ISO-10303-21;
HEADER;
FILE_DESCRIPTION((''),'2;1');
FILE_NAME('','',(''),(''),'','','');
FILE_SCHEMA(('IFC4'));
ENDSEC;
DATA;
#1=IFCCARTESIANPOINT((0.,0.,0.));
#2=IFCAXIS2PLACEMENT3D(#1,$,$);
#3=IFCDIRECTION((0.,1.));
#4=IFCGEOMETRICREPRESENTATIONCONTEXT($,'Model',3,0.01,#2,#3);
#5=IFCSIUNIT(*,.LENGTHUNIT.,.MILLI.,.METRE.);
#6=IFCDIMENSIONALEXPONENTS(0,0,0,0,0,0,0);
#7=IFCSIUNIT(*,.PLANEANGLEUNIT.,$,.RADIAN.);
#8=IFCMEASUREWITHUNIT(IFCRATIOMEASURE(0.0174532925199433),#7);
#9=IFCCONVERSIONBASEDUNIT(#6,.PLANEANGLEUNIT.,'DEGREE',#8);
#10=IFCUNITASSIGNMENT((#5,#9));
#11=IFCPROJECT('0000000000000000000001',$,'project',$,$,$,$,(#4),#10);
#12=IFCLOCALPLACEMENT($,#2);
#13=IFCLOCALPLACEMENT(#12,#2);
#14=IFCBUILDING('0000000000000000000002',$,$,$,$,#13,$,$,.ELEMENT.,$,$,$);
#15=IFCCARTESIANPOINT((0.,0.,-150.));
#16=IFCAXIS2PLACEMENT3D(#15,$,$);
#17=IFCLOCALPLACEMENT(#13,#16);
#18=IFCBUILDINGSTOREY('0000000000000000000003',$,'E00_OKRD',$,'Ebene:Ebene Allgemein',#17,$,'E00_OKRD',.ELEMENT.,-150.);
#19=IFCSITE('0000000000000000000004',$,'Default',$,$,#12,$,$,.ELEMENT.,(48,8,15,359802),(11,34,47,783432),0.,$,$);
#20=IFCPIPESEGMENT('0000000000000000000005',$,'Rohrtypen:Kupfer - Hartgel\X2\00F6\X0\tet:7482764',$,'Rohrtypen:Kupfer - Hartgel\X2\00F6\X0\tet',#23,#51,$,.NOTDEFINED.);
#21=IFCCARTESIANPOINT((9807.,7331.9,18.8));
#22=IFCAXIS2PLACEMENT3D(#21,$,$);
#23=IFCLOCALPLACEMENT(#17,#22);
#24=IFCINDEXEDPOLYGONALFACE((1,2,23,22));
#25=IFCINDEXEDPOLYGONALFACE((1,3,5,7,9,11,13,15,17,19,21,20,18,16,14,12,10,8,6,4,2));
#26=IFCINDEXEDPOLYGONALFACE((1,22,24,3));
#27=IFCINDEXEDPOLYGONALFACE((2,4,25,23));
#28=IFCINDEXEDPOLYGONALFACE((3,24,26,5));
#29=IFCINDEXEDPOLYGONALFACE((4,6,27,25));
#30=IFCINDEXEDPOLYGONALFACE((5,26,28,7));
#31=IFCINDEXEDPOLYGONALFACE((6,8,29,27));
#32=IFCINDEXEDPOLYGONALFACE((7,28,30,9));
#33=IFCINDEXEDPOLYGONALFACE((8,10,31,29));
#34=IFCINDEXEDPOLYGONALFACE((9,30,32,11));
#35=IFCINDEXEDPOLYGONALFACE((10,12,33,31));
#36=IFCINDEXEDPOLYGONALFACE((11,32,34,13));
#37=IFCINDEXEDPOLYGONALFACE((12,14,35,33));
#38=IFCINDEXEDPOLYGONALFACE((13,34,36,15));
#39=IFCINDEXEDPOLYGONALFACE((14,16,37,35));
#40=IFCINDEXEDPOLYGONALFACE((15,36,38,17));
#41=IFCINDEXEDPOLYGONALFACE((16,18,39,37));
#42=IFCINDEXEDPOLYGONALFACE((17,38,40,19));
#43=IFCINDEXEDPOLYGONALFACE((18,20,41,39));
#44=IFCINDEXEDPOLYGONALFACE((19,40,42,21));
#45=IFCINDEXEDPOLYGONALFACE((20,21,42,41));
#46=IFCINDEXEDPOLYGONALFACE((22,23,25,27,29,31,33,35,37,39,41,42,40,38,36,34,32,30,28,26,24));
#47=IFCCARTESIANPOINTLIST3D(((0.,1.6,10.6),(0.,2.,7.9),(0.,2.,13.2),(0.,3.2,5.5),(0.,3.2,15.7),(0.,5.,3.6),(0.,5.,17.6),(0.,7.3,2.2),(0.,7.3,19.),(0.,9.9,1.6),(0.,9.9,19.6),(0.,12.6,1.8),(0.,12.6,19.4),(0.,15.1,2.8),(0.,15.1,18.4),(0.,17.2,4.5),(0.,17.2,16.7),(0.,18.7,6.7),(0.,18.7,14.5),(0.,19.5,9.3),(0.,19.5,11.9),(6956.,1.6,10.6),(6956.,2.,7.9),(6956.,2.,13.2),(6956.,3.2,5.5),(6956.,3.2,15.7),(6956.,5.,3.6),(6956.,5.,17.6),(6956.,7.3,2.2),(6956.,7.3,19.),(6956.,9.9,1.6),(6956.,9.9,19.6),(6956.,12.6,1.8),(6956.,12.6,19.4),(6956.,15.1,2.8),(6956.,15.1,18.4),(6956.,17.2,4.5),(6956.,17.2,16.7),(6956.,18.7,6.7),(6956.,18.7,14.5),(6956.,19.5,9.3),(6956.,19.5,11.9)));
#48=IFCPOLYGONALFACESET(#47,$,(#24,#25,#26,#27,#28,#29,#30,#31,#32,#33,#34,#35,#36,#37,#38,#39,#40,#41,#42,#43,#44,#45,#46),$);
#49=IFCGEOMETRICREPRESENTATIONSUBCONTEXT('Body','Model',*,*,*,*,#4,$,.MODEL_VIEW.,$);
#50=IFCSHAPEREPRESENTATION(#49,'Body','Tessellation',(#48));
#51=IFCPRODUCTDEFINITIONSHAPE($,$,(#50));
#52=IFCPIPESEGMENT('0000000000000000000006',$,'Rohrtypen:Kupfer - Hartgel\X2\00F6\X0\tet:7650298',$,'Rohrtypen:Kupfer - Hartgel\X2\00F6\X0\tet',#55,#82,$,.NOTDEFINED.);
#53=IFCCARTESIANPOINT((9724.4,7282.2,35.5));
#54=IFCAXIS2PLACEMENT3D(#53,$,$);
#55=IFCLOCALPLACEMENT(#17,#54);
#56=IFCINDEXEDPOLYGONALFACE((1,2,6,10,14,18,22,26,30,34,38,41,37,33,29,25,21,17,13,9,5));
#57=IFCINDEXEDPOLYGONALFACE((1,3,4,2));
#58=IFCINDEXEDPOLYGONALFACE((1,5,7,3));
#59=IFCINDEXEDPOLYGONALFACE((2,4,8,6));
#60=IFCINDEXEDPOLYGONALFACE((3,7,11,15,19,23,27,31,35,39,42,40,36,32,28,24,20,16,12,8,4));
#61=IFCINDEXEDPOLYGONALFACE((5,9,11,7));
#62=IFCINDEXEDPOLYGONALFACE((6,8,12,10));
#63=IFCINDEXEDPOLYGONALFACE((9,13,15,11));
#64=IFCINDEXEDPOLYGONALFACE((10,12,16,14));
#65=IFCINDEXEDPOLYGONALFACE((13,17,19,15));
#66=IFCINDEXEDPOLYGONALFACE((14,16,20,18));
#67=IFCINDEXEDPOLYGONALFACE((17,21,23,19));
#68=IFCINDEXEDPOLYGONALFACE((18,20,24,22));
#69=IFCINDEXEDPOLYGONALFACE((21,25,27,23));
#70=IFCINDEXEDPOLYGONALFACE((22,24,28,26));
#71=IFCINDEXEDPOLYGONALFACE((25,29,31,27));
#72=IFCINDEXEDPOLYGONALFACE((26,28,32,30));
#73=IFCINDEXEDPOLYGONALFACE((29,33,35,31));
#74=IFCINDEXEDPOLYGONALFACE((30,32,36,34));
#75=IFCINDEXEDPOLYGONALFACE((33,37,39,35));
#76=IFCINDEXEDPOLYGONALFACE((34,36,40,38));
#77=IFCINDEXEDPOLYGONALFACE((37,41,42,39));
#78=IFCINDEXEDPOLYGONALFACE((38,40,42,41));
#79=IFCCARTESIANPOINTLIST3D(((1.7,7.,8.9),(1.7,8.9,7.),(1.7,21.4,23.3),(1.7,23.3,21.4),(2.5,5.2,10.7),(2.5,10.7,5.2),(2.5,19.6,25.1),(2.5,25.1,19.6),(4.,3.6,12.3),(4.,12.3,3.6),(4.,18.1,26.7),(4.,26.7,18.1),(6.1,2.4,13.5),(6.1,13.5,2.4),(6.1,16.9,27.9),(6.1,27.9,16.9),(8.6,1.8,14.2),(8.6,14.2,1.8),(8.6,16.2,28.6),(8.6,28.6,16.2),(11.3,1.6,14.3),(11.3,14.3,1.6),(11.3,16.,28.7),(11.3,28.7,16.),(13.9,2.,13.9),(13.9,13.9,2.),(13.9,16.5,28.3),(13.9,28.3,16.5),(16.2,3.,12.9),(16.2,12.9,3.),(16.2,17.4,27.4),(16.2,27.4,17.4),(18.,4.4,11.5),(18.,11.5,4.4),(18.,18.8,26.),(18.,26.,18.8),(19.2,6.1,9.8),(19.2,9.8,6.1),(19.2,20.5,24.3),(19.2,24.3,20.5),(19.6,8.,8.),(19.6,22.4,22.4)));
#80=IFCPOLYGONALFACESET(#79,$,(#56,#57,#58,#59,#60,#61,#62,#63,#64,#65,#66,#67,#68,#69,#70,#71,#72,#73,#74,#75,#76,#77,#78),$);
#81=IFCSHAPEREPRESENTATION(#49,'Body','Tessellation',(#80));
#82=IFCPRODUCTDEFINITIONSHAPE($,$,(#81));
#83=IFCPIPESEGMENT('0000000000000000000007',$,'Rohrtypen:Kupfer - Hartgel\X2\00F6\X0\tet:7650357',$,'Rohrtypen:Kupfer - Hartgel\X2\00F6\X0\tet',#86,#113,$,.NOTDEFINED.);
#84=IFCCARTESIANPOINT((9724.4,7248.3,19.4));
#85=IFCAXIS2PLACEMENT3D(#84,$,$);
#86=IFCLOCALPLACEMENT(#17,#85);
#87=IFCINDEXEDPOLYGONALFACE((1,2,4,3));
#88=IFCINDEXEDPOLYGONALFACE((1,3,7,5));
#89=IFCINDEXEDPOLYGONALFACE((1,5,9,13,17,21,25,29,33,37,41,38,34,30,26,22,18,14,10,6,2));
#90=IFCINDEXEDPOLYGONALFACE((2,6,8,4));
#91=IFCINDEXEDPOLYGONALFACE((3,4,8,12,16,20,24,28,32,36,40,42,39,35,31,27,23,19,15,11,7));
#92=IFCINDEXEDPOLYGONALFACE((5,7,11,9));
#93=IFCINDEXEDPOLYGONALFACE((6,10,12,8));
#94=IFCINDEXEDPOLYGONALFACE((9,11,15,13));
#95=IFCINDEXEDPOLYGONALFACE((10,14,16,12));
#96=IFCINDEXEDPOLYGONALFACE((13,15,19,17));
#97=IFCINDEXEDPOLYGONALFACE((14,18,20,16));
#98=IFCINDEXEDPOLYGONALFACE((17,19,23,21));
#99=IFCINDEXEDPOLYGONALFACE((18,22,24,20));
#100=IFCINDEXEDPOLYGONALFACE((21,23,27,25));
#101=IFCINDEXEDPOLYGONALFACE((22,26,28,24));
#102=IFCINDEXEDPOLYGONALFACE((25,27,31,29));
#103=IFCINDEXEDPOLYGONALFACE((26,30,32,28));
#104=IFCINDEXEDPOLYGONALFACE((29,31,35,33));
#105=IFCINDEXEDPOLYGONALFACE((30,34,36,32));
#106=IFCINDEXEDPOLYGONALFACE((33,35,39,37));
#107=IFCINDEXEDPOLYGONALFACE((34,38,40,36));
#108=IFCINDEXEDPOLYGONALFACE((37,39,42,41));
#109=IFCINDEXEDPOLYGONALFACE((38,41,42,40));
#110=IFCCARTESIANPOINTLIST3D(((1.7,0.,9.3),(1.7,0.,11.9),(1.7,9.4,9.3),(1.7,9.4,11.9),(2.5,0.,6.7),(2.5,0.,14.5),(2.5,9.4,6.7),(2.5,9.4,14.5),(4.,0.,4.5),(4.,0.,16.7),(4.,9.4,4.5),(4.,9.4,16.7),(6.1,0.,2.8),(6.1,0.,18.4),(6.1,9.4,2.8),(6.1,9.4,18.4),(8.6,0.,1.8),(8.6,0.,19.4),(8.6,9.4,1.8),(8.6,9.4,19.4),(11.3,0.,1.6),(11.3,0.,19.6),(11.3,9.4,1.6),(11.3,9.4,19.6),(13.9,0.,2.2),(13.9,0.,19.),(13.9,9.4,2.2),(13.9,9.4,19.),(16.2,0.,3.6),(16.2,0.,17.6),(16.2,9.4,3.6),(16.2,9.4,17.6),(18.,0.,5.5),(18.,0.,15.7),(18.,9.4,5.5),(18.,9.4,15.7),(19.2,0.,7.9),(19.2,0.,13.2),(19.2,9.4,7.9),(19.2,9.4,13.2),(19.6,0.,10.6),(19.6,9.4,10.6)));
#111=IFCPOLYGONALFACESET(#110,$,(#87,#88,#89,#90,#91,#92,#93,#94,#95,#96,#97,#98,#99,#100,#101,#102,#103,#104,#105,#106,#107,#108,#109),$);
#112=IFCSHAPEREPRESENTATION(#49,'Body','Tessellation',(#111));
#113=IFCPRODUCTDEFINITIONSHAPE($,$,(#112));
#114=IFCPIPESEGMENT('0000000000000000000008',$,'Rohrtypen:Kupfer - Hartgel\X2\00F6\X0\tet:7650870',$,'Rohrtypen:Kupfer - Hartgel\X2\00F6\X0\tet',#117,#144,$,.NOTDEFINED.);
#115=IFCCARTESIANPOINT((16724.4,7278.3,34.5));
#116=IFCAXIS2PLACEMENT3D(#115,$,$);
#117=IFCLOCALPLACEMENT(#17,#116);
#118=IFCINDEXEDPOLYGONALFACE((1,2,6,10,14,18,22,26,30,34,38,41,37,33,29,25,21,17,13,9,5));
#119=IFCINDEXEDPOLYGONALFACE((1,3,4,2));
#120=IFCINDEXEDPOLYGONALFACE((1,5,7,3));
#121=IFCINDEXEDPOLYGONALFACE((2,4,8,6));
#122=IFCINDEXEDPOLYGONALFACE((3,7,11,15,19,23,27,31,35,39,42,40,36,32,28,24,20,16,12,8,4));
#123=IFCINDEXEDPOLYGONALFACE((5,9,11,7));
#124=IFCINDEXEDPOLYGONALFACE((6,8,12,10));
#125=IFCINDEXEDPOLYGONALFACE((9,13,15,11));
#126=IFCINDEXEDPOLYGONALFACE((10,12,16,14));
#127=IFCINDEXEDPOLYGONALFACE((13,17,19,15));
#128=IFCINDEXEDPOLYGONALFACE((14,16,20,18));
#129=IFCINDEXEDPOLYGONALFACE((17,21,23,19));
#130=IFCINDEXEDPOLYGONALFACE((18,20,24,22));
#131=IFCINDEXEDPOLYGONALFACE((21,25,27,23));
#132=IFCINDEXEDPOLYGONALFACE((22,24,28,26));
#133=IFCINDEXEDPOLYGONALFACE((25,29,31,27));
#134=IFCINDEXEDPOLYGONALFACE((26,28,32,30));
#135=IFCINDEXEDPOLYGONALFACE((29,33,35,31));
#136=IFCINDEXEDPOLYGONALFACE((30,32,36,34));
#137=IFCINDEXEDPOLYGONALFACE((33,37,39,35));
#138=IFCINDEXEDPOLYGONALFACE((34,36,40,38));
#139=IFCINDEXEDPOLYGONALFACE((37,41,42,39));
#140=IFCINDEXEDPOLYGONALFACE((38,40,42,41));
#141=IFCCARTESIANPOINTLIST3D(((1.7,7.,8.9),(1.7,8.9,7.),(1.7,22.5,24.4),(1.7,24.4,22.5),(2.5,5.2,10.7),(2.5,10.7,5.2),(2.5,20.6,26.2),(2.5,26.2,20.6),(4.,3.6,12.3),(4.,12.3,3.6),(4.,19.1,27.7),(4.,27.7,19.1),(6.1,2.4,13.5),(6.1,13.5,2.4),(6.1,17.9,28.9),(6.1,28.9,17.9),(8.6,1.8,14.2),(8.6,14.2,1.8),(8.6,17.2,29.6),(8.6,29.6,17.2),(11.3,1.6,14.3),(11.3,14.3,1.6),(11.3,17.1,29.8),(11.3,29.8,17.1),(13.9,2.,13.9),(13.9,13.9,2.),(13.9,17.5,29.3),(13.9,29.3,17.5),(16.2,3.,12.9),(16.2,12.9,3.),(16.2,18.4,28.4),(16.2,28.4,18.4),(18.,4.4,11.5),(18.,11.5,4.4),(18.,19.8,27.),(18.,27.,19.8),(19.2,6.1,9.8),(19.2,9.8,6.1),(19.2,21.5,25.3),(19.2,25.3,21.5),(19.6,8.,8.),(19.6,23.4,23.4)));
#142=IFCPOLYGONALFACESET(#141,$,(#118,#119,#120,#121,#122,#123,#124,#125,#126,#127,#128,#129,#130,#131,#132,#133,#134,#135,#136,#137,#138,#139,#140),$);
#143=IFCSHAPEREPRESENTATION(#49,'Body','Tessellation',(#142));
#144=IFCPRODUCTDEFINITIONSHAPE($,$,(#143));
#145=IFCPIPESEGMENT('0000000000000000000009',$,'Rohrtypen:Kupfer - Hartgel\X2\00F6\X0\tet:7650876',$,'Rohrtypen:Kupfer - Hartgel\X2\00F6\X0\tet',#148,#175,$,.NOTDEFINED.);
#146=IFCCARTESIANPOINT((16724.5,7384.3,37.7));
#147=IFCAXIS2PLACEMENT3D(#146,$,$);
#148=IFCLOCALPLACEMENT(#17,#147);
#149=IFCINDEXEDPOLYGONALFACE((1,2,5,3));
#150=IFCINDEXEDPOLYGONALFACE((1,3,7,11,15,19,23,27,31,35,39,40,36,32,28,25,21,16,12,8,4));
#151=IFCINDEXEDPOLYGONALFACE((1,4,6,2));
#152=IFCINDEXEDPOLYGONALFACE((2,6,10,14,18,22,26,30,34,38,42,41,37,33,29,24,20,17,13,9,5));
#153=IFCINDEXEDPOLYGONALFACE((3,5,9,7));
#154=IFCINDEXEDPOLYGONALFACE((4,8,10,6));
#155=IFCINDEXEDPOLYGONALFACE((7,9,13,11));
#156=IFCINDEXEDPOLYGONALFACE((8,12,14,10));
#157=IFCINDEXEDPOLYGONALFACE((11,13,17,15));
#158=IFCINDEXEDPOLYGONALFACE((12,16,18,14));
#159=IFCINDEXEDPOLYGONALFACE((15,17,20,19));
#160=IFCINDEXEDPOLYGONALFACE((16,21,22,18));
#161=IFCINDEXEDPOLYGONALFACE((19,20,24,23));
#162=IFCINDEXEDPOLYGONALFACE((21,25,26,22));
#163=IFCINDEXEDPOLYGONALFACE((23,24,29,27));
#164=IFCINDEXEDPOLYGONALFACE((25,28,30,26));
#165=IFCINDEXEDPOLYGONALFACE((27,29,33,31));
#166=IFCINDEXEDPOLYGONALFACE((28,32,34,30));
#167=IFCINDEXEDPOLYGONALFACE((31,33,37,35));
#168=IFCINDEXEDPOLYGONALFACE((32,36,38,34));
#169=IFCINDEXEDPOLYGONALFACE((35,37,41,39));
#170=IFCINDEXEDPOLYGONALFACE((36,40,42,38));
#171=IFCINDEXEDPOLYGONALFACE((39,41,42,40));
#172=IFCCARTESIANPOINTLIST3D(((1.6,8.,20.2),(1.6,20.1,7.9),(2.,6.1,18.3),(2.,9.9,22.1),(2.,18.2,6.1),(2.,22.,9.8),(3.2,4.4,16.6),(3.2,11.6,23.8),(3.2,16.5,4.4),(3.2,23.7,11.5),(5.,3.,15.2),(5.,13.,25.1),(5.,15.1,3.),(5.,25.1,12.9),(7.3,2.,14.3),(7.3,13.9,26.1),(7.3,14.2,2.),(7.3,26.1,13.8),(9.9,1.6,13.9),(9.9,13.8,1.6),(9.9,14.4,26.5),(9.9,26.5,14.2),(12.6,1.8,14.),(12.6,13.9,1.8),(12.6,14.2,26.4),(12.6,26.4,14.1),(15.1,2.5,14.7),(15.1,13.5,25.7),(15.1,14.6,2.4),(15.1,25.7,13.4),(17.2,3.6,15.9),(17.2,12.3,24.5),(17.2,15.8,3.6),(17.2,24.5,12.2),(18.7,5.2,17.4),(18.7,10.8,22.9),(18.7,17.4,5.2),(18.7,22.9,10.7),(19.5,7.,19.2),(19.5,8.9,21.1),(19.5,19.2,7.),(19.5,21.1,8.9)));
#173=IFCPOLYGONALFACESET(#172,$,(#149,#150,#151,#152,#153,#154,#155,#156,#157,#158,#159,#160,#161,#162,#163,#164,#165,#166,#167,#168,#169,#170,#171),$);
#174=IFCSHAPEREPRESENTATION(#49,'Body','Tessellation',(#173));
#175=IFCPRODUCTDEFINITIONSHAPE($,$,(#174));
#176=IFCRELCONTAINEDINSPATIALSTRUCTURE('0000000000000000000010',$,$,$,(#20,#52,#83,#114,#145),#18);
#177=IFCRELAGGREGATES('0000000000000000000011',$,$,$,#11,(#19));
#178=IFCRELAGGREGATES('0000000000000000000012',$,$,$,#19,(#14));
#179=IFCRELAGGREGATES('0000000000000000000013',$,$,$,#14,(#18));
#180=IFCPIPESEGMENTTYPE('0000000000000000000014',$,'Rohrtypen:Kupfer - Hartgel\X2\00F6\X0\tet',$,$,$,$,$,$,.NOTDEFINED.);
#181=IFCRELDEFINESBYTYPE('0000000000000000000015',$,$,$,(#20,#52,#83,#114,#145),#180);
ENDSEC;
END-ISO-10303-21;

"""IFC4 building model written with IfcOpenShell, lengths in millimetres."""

from ifc_helpers import new_model, entity, si_unit, converted_unit, direction, frame, frame_2d, origin, place, context, subcontext, project, spatial, circle, extrude, type_object, element, save


model = new_model("IFC4")

# Units and contexts
model_context = context("Model", 3, precision=0.01, world=origin(), true_north=direction((0.0, 1.0)))
body_context = subcontext(model_context, "Body", "Model", "MODEL_VIEW")
ifc_project = project(units=[si_unit("LENGTHUNIT", "METRE", prefix="MILLI"), converted_unit("PLANEANGLEUNIT", "DEGREE", entity("IfcRatioMeasure", 0.0174532925199433), si_unit("PLANEANGLEUNIT", "RADIAN"), dimensions=[0, 0, 0, 0, 0, 0, 0])], contexts=[model_context])

# Site, building, storey
site_placement = place(None, origin())
site = spatial("IfcSite", under=ifc_project, at=site_placement, Name="Default", CompositionType="ELEMENT", RefLatitude=(48, 8, 15, 359802), RefLongitude=(11, 34, 47, 783432), RefElevation=0.0)
building_placement = place(site_placement, origin())
building = spatial("IfcBuilding", under=site, at=building_placement, CompositionType="ELEMENT")
storey_placement = place(building_placement, frame((0.0, 0.0, -150.0)))
storey = spatial("IfcBuildingStorey", under=building, at=storey_placement, Name="E00_OKRD", ObjectType="Ebene:Ebene Allgemein", LongName="E00_OKRD", CompositionType="ELEMENT", Elevation=-150.0)

# Pipe segments
pipe_segment_type = type_object("IfcPipeSegmentType", Name="Rohrtypen:Kupfer - Hartgelötet", PredefinedType="NOTDEFINED")
pipe_segment_1_placement = place(storey_placement, frame((9807.0, 7331.9, 18.8)))
element("IfcPipeSegment", 1, at=pipe_segment_1_placement, inside=storey, type_object=pipe_segment_type, Name="Rohrtypen:Kupfer - Hartgelötet:7482764", ObjectType="Rohrtypen:Kupfer - Hartgelötet", PredefinedType="NOTDEFINED", context=body_context, shape_type="SweptSolid", body=[
    extrude(circle(Radius=9.0, at=frame_2d((0.0, 0.0), x_axis=(1.0, 0.0))), frame((0.0, 10.6, 10.6), z_axis=(1.0, 0.0, 0.0), x_axis=(0.0, -1.0, 0.0)), (0.0, 0.0, 1.0), 6956.0),
])
pipe_segment_2_placement = place(storey_placement, frame((9724.4, 7282.2, 35.5)))
element("IfcPipeSegment", 2, at=pipe_segment_2_placement, inside=storey, type_object=pipe_segment_type, Name="Rohrtypen:Kupfer - Hartgelötet:7650298", ObjectType="Rohrtypen:Kupfer - Hartgelötet", PredefinedType="NOTDEFINED", context=body_context, shape_type="SweptSolid", body=[
    extrude(circle(Radius=9.0, at=frame_2d((0.0, 0.0), x_axis=(1.0, 0.0))), frame((10.6, 8.0, 8.0), z_axis=(0.0, 0.707107, 0.707107), x_axis=(1.0, 0.0, 0.0)), (0.0, 0.0, 1.0), 20.4),
])
pipe_segment_3_placement = place(storey_placement, frame((9724.4, 7248.3, 19.4)))
element("IfcPipeSegment", 3, at=pipe_segment_3_placement, inside=storey, type_object=pipe_segment_type, Name="Rohrtypen:Kupfer - Hartgelötet:7650357", ObjectType="Rohrtypen:Kupfer - Hartgelötet", PredefinedType="NOTDEFINED", context=body_context, shape_type="SweptSolid", body=[
    extrude(circle(Radius=9.0, at=frame_2d((0.0, 0.0), x_axis=(1.0, 0.0))), frame((10.6, 0.0, 10.6), z_axis=(0.0, 1.0, 0.0), x_axis=(1.0, 0.0, 0.0)), (0.0, 0.0, 1.0), 9.4),
])
pipe_segment_4_placement = place(storey_placement, frame((16724.4, 7278.3, 34.5)))
element("IfcPipeSegment", 4, at=pipe_segment_4_placement, inside=storey, type_object=pipe_segment_type, Name="Rohrtypen:Kupfer - Hartgelötet:7650870", ObjectType="Rohrtypen:Kupfer - Hartgelötet", PredefinedType="NOTDEFINED", context=body_context, shape_type="SweptSolid", body=[
    extrude(circle(Radius=9.0, at=frame_2d((0.0, 0.0), x_axis=(1.0, 0.0))), frame((10.6, 8.0, 8.0), z_axis=(0.0, 0.707107, 0.707107), x_axis=(1.0, 0.0, 0.0)), (0.0, 0.0, 1.0), 21.8),
])
pipe_segment_5_placement = place(storey_placement, frame((16724.5, 7384.3, 37.7)))
element("IfcPipeSegment", 5, at=pipe_segment_5_placement, inside=storey, type_object=pipe_segment_type, Name="Rohrtypen:Kupfer - Hartgelötet:7650876", ObjectType="Rohrtypen:Kupfer - Hartgelötet", PredefinedType="NOTDEFINED", context=body_context, shape_type="SweptSolid", body=[
    extrude(circle(Radius=9.0, at=frame_2d((0.0, 0.0), x_axis=(1.0, 0.0))), frame((10.6, 8.0, 20.2), z_axis=(0.0, 0.70394, -0.71026), x_axis=(-1.0, 0.0, 0.0)), (0.0, 0.0, 1.0), 17.3),
])

save(model, "model.ifc")
